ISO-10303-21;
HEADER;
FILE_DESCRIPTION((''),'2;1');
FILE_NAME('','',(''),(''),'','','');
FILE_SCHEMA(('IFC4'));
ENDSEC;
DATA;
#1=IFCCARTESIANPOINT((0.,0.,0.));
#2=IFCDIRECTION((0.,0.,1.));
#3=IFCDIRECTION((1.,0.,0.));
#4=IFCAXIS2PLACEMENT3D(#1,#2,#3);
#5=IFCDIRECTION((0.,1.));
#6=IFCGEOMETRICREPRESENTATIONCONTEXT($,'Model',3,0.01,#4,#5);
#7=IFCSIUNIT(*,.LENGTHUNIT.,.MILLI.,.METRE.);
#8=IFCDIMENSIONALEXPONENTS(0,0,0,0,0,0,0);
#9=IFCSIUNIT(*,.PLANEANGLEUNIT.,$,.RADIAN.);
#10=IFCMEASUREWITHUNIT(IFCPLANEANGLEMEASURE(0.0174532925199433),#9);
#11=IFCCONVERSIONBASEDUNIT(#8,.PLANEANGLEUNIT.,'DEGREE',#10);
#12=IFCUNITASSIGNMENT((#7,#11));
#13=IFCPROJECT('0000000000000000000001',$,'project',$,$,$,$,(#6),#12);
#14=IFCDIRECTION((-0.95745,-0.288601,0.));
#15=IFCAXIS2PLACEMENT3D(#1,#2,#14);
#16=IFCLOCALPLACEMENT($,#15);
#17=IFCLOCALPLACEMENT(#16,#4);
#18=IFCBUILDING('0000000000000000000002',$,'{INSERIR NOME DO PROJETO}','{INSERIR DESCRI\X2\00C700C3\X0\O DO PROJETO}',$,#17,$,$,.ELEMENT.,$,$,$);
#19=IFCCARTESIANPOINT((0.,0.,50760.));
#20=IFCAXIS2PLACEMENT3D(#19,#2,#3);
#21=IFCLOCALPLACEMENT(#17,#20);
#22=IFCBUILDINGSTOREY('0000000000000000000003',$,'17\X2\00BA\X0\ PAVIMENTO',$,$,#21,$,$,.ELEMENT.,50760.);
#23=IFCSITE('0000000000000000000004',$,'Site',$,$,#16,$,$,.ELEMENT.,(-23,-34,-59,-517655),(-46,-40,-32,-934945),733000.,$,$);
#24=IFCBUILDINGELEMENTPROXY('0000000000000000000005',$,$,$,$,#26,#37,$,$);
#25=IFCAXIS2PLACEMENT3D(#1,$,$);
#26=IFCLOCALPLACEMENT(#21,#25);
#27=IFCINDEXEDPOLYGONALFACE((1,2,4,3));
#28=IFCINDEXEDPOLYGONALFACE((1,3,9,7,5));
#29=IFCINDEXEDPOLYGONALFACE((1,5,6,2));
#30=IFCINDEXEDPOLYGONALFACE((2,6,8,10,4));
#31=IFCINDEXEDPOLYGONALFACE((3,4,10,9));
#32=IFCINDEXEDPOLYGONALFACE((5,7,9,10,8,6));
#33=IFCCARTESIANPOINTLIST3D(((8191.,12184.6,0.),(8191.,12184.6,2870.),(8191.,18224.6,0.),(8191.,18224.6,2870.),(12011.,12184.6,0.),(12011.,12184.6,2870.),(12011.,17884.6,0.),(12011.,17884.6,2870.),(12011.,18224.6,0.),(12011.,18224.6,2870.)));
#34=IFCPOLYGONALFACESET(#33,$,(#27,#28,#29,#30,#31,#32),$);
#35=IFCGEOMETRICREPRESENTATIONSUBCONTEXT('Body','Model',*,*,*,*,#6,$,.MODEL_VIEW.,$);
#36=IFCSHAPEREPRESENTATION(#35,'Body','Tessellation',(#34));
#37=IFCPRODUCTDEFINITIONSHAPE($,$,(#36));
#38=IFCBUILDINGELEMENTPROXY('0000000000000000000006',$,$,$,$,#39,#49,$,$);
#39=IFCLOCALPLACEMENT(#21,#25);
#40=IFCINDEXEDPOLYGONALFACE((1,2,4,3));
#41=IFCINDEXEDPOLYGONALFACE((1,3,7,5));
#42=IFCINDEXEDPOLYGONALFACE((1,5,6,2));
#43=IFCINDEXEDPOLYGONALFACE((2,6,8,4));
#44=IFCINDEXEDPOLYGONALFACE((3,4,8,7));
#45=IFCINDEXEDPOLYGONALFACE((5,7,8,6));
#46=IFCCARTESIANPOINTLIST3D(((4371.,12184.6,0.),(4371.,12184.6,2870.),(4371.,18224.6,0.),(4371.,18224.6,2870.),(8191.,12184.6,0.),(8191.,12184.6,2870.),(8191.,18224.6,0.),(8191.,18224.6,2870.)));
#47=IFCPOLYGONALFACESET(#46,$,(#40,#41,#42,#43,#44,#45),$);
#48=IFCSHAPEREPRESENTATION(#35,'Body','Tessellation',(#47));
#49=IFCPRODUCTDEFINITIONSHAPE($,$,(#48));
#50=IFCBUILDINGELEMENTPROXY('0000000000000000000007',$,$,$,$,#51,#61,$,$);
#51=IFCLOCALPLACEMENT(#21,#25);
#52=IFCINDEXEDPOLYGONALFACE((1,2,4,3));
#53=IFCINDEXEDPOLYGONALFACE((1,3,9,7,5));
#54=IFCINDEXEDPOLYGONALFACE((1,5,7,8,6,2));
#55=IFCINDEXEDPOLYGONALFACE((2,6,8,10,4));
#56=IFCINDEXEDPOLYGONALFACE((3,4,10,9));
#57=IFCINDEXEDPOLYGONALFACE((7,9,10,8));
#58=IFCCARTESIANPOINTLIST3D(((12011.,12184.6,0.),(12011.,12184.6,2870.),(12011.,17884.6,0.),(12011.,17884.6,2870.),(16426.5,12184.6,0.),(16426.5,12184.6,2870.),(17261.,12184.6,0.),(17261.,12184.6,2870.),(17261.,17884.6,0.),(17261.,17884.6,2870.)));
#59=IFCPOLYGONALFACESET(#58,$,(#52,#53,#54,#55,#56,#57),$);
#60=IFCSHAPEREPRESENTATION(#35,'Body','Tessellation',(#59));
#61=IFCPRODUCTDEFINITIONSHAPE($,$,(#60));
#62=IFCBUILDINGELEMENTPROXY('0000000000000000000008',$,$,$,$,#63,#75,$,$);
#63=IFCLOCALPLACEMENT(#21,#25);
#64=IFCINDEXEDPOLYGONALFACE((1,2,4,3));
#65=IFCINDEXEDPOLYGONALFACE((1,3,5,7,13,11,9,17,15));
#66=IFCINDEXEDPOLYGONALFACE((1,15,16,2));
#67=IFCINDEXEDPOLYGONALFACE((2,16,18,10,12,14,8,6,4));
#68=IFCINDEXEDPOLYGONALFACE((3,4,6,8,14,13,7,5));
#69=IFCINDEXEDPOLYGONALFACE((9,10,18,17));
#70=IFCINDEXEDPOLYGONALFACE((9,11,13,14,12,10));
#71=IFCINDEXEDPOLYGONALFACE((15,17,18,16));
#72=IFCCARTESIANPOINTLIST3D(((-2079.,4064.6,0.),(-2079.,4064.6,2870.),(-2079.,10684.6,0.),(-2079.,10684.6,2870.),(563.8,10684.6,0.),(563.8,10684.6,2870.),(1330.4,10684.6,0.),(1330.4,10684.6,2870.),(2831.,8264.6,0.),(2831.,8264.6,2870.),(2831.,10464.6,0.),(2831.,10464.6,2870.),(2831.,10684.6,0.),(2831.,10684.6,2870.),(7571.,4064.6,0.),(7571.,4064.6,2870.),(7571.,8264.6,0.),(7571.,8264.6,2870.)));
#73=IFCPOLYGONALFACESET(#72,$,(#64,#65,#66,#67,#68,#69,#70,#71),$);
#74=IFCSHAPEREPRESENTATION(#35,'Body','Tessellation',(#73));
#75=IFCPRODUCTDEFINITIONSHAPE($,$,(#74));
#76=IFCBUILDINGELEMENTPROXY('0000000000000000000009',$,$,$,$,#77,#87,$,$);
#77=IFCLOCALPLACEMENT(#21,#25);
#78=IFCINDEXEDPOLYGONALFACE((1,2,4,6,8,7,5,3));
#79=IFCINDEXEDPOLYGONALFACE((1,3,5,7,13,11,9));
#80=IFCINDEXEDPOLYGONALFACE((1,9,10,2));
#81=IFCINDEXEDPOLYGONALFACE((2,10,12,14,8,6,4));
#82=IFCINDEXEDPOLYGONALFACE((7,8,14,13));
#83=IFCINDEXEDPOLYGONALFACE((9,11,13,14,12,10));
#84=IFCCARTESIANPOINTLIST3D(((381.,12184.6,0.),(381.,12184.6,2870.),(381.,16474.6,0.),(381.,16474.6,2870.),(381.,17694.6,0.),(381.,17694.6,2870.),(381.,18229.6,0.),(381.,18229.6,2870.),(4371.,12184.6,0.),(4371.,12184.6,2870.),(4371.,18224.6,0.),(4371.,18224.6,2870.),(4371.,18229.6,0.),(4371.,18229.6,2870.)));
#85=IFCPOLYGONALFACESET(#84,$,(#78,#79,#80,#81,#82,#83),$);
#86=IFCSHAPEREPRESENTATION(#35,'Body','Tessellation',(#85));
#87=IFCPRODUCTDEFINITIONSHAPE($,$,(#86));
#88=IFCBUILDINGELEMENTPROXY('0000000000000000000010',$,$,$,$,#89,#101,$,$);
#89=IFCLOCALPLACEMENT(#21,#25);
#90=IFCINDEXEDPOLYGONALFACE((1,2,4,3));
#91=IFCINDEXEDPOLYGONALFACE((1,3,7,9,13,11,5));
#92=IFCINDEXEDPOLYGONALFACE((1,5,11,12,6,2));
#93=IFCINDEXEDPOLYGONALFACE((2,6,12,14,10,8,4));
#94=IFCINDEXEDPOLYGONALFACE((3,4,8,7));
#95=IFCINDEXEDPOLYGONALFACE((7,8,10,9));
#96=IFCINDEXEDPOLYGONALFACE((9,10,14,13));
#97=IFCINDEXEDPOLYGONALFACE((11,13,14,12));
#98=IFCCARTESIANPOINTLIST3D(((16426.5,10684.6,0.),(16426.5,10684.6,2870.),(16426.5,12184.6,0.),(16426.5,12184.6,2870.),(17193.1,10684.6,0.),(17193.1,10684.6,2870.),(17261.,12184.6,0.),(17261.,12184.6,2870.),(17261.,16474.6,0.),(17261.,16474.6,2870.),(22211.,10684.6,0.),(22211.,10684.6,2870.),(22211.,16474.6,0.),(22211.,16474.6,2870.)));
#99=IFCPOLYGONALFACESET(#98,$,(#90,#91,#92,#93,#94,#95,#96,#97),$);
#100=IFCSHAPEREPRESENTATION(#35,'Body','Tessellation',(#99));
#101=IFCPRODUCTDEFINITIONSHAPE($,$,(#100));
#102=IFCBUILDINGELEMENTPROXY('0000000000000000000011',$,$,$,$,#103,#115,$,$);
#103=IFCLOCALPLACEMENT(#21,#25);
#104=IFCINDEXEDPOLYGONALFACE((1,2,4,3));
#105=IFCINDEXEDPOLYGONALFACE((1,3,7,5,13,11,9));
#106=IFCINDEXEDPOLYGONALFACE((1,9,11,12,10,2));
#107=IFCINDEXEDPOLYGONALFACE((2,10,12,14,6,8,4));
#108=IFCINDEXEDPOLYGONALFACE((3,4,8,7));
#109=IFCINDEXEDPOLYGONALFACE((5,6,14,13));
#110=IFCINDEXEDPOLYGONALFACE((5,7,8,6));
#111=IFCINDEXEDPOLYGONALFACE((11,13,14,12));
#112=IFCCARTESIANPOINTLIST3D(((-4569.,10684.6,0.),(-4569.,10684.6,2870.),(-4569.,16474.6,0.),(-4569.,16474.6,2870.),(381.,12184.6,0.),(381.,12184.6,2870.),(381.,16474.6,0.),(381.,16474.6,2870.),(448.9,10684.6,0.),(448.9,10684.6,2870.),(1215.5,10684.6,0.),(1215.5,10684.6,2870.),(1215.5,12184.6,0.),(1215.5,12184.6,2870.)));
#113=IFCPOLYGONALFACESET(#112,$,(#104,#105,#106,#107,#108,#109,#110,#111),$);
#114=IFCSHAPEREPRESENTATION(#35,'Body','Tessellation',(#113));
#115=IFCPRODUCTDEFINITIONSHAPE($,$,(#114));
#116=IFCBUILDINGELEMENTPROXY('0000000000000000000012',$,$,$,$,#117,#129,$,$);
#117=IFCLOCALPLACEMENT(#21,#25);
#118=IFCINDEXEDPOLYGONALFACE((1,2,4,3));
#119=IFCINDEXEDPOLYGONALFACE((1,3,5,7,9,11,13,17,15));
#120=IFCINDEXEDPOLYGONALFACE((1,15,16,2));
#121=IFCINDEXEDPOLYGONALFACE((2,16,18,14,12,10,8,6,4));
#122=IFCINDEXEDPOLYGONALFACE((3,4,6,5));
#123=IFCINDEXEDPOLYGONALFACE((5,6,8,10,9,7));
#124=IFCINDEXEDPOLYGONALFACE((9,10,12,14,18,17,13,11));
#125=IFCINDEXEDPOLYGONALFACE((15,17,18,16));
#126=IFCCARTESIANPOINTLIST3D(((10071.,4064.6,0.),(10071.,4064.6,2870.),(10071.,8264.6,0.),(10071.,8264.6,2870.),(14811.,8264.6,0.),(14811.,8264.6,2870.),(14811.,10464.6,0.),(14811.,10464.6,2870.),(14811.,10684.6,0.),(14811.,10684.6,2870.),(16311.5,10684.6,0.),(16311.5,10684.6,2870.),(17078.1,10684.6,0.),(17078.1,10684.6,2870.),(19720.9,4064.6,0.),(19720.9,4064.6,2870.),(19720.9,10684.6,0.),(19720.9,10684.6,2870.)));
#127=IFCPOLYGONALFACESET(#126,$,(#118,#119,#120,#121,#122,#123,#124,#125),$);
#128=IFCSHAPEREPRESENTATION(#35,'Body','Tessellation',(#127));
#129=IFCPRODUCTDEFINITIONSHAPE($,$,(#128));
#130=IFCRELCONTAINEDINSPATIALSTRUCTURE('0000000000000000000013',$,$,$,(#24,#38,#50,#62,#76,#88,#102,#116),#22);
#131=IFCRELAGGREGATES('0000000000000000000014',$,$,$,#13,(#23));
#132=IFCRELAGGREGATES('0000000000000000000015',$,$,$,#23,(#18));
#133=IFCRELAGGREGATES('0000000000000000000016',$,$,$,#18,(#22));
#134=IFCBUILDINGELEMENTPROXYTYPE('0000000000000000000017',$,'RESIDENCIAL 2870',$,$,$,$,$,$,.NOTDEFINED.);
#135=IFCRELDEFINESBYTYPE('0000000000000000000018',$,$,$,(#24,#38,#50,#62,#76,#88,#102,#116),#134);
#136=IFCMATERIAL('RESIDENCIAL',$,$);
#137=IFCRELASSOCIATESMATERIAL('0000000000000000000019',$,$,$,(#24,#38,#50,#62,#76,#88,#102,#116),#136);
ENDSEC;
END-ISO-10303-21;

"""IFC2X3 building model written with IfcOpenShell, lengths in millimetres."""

from ifc_helpers import new_model, entity, si_unit, converted_unit, direction, frame, origin_with_axes, place, context, subcontext, project, spatial, polyline, outline, extrude, material, type_object, element, save


model = new_model("IFC2X3")

# Units and contexts
model_context = context("Model", 3, precision=0.01, world=origin_with_axes(), true_north=direction((0.0, 1.0)))
body_context = subcontext(model_context, "Body", "Model", "MODEL_VIEW")
ifc_project = project(units=[si_unit("LENGTHUNIT", "METRE", prefix="MILLI"), converted_unit("PLANEANGLEUNIT", "DEGREE", entity("IfcPlaneAngleMeasure", 0.0174532925199433), si_unit("PLANEANGLEUNIT", "RADIAN"), dimensions=[0, 0, 0, 0, 0, 0, 0])], contexts=[model_context])

# Site, building, storey
site_placement = place(None, frame((0.0, 0.0, 0.0), z_axis=(0.0, 0.0, 1.0), x_axis=(-0.95745, -0.288601, 0.0)))
site = spatial("IfcSite", under=ifc_project, at=site_placement, Name="Site", CompositionType="ELEMENT", RefLatitude=(-23, -34, -59, -517655), RefLongitude=(-46, -40, -32, -934945), RefElevation=733000.0)
building_placement = place(site_placement, origin_with_axes())
building = spatial("IfcBuilding", under=site, at=building_placement, Name="{INSERIR NOME DO PROJETO}", Description="{INSERIR DESCRIÇÃO DO PROJETO}", CompositionType="ELEMENT")
storey_placement = place(building_placement, frame((0.0, 0.0, 50760.0), z_axis=(0.0, 0.0, 1.0), x_axis=(1.0, 0.0, 0.0)))
storey = spatial("IfcBuildingStorey", under=building, at=storey_placement, Name="17º PAVIMENTO", CompositionType="ELEMENT", Elevation=50760.0)

# Building element proxies
ifc_material_1 = material(Name="RESIDENCIAL")
building_element_proxy_type_1 = type_object("IfcBuildingElementProxyType", Name="RESIDENCIAL 2870", PredefinedType="NOTDEFINED")
proxy_1_placement = place(storey_placement, frame((8191.0, 18224.6, 0.0), z_axis=(0.0, 0.0, 1.0), x_axis=(1.0, 0.0, 0.0)))
element("IfcBuildingElementProxy", 1, at=proxy_1_placement, inside=storey, type_object=building_element_proxy_type_1, material=ifc_material_1, context=body_context, shape_type="SweptSolid", body=[
    extrude(outline(polyline([(0.0, 0.0), (0.0, -6040.0), (3820.0, -6040.0), (3820.0, -340.0), (3820.0, 0.0), (0.0, 0.0)])), origin_with_axes(), (0.0, 0.0, 1.0), 2870.0),
])
proxy_2_placement = place(storey_placement, frame((4371.0, 18224.6, 0.0), z_axis=(0.0, 0.0, 1.0), x_axis=(1.0, 0.0, 0.0)))
element("IfcBuildingElementProxy", 2, at=proxy_2_placement, inside=storey, type_object=building_element_proxy_type_1, material=ifc_material_1, context=body_context, shape_type="SweptSolid", body=[
    extrude(outline(polyline([(0.0, 0.0), (0.0, -6040.0), (3820.0, -6040.0), (3820.0, 0.0), (0.0, 0.0)])), origin_with_axes(), (0.0, 0.0, 1.0), 2870.0),
])
proxy_3_placement = place(storey_placement, frame((12011.0, 12184.6, 0.0), z_axis=(0.0, 0.0, 1.0), x_axis=(1.0, 0.0, 0.0)))
element("IfcBuildingElementProxy", 3, at=proxy_3_placement, inside=storey, type_object=building_element_proxy_type_1, material=ifc_material_1, context=body_context, shape_type="SweptSolid", body=[
    extrude(outline(polyline([(0.0, 0.0), (4415.5, 0.0), (5250.0, 0.0), (5250.0, 5700.0), (0.0, 5700.0), (0.0, 0.0)])), origin_with_axes(), (0.0, 0.0, 1.0), 2870.0),
])
proxy_4_placement = place(storey_placement, frame((-2079.0, 4064.6, 0.0), z_axis=(0.0, 0.0, 1.0), x_axis=(1.0, 0.0, 0.0)))
element("IfcBuildingElementProxy", 4, at=proxy_4_placement, inside=storey, type_object=building_element_proxy_type_1, material=ifc_material_1, context=body_context, shape_type="SweptSolid", body=[
    extrude(outline(polyline([(0.0, 0.0), (9650.0, 0.0), (9650.0, 4200.0), (4910.0, 4200.0), (4910.0, 6400.0), (4910.0, 6620.0), (3409.4, 6620.0), (2642.8, 6620.0), (0.0, 6620.0), (0.0, 0.0)])), origin_with_axes(), (0.0, 0.0, 1.0), 2870.0),
])
proxy_5_placement = place(storey_placement, frame((381.0, 16474.6, 0.0), z_axis=(0.0, 0.0, 1.0), x_axis=(1.0, 0.0, 0.0)))
element("IfcBuildingElementProxy", 5, at=proxy_5_placement, inside=storey, type_object=building_element_proxy_type_1, material=ifc_material_1, context=body_context, shape_type="SweptSolid", body=[
    extrude(outline(polyline([(0.0, 0.0), (0.0, -4290.0), (3990.0, -4290.0), (3990.0, 1750.0), (3990.0, 1755.0), (0.0, 1755.0), (0.0, 1220.0), (0.0, 0.0)])), origin_with_axes(), (0.0, 0.0, 1.0), 2870.0),
])
proxy_6_placement = place(storey_placement, frame((17261.0, 12184.6, 0.0), z_axis=(0.0, 0.0, 1.0), x_axis=(1.0, 0.0, 0.0)))
element("IfcBuildingElementProxy", 6, at=proxy_6_placement, inside=storey, type_object=building_element_proxy_type_1, material=ifc_material_1, context=body_context, shape_type="SweptSolid", body=[
    extrude(outline(polyline([(0.0, 0.0), (-834.5, 0.0), (-834.5, -1500.0), (-67.9, -1500.0), (4950.0, -1500.0), (4950.0, 4290.0), (0.0, 4290.0), (0.0, 0.0)])), origin_with_axes(), (0.0, 0.0, 1.0), 2870.0),
])
proxy_7_placement = place(storey_placement, frame((-4569.0, 16474.6, 0.0), z_axis=(0.0, 0.0, 1.0), x_axis=(1.0, 0.0, 0.0)))
element("IfcBuildingElementProxy", 7, at=proxy_7_placement, inside=storey, type_object=building_element_proxy_type_1, material=ifc_material_1, context=body_context, shape_type="SweptSolid", body=[
    extrude(outline(polyline([(0.0, 0.0), (0.0, -5790.0), (5017.9, -5790.0), (5784.5, -5790.0), (5784.5, -4290.0), (4950.0, -4290.0), (4950.0, 0.0), (0.0, 0.0)])), origin_with_axes(), (0.0, 0.0, 1.0), 2870.0),
])
proxy_8_placement = place(storey_placement, frame((19720.9, 4064.6, 0.0), z_axis=(0.0, 0.0, 1.0), x_axis=(1.0, 0.0, 0.0)))
element("IfcBuildingElementProxy", 8, at=proxy_8_placement, inside=storey, type_object=building_element_proxy_type_1, material=ifc_material_1, context=body_context, shape_type="SweptSolid", body=[
    extrude(outline(polyline([(0.0, 0.0), (0.0, 6620.0), (-2642.8, 6620.0), (-3409.4, 6620.0), (-4910.0, 6620.0), (-4910.0, 6400.0), (-4910.0, 4200.0), (-9650.0, 4200.0), (-9650.0, 0.0), (0.0, 0.0)])), origin_with_axes(), (0.0, 0.0, 1.0), 2870.0),
])

save(model, "model.ifc")
